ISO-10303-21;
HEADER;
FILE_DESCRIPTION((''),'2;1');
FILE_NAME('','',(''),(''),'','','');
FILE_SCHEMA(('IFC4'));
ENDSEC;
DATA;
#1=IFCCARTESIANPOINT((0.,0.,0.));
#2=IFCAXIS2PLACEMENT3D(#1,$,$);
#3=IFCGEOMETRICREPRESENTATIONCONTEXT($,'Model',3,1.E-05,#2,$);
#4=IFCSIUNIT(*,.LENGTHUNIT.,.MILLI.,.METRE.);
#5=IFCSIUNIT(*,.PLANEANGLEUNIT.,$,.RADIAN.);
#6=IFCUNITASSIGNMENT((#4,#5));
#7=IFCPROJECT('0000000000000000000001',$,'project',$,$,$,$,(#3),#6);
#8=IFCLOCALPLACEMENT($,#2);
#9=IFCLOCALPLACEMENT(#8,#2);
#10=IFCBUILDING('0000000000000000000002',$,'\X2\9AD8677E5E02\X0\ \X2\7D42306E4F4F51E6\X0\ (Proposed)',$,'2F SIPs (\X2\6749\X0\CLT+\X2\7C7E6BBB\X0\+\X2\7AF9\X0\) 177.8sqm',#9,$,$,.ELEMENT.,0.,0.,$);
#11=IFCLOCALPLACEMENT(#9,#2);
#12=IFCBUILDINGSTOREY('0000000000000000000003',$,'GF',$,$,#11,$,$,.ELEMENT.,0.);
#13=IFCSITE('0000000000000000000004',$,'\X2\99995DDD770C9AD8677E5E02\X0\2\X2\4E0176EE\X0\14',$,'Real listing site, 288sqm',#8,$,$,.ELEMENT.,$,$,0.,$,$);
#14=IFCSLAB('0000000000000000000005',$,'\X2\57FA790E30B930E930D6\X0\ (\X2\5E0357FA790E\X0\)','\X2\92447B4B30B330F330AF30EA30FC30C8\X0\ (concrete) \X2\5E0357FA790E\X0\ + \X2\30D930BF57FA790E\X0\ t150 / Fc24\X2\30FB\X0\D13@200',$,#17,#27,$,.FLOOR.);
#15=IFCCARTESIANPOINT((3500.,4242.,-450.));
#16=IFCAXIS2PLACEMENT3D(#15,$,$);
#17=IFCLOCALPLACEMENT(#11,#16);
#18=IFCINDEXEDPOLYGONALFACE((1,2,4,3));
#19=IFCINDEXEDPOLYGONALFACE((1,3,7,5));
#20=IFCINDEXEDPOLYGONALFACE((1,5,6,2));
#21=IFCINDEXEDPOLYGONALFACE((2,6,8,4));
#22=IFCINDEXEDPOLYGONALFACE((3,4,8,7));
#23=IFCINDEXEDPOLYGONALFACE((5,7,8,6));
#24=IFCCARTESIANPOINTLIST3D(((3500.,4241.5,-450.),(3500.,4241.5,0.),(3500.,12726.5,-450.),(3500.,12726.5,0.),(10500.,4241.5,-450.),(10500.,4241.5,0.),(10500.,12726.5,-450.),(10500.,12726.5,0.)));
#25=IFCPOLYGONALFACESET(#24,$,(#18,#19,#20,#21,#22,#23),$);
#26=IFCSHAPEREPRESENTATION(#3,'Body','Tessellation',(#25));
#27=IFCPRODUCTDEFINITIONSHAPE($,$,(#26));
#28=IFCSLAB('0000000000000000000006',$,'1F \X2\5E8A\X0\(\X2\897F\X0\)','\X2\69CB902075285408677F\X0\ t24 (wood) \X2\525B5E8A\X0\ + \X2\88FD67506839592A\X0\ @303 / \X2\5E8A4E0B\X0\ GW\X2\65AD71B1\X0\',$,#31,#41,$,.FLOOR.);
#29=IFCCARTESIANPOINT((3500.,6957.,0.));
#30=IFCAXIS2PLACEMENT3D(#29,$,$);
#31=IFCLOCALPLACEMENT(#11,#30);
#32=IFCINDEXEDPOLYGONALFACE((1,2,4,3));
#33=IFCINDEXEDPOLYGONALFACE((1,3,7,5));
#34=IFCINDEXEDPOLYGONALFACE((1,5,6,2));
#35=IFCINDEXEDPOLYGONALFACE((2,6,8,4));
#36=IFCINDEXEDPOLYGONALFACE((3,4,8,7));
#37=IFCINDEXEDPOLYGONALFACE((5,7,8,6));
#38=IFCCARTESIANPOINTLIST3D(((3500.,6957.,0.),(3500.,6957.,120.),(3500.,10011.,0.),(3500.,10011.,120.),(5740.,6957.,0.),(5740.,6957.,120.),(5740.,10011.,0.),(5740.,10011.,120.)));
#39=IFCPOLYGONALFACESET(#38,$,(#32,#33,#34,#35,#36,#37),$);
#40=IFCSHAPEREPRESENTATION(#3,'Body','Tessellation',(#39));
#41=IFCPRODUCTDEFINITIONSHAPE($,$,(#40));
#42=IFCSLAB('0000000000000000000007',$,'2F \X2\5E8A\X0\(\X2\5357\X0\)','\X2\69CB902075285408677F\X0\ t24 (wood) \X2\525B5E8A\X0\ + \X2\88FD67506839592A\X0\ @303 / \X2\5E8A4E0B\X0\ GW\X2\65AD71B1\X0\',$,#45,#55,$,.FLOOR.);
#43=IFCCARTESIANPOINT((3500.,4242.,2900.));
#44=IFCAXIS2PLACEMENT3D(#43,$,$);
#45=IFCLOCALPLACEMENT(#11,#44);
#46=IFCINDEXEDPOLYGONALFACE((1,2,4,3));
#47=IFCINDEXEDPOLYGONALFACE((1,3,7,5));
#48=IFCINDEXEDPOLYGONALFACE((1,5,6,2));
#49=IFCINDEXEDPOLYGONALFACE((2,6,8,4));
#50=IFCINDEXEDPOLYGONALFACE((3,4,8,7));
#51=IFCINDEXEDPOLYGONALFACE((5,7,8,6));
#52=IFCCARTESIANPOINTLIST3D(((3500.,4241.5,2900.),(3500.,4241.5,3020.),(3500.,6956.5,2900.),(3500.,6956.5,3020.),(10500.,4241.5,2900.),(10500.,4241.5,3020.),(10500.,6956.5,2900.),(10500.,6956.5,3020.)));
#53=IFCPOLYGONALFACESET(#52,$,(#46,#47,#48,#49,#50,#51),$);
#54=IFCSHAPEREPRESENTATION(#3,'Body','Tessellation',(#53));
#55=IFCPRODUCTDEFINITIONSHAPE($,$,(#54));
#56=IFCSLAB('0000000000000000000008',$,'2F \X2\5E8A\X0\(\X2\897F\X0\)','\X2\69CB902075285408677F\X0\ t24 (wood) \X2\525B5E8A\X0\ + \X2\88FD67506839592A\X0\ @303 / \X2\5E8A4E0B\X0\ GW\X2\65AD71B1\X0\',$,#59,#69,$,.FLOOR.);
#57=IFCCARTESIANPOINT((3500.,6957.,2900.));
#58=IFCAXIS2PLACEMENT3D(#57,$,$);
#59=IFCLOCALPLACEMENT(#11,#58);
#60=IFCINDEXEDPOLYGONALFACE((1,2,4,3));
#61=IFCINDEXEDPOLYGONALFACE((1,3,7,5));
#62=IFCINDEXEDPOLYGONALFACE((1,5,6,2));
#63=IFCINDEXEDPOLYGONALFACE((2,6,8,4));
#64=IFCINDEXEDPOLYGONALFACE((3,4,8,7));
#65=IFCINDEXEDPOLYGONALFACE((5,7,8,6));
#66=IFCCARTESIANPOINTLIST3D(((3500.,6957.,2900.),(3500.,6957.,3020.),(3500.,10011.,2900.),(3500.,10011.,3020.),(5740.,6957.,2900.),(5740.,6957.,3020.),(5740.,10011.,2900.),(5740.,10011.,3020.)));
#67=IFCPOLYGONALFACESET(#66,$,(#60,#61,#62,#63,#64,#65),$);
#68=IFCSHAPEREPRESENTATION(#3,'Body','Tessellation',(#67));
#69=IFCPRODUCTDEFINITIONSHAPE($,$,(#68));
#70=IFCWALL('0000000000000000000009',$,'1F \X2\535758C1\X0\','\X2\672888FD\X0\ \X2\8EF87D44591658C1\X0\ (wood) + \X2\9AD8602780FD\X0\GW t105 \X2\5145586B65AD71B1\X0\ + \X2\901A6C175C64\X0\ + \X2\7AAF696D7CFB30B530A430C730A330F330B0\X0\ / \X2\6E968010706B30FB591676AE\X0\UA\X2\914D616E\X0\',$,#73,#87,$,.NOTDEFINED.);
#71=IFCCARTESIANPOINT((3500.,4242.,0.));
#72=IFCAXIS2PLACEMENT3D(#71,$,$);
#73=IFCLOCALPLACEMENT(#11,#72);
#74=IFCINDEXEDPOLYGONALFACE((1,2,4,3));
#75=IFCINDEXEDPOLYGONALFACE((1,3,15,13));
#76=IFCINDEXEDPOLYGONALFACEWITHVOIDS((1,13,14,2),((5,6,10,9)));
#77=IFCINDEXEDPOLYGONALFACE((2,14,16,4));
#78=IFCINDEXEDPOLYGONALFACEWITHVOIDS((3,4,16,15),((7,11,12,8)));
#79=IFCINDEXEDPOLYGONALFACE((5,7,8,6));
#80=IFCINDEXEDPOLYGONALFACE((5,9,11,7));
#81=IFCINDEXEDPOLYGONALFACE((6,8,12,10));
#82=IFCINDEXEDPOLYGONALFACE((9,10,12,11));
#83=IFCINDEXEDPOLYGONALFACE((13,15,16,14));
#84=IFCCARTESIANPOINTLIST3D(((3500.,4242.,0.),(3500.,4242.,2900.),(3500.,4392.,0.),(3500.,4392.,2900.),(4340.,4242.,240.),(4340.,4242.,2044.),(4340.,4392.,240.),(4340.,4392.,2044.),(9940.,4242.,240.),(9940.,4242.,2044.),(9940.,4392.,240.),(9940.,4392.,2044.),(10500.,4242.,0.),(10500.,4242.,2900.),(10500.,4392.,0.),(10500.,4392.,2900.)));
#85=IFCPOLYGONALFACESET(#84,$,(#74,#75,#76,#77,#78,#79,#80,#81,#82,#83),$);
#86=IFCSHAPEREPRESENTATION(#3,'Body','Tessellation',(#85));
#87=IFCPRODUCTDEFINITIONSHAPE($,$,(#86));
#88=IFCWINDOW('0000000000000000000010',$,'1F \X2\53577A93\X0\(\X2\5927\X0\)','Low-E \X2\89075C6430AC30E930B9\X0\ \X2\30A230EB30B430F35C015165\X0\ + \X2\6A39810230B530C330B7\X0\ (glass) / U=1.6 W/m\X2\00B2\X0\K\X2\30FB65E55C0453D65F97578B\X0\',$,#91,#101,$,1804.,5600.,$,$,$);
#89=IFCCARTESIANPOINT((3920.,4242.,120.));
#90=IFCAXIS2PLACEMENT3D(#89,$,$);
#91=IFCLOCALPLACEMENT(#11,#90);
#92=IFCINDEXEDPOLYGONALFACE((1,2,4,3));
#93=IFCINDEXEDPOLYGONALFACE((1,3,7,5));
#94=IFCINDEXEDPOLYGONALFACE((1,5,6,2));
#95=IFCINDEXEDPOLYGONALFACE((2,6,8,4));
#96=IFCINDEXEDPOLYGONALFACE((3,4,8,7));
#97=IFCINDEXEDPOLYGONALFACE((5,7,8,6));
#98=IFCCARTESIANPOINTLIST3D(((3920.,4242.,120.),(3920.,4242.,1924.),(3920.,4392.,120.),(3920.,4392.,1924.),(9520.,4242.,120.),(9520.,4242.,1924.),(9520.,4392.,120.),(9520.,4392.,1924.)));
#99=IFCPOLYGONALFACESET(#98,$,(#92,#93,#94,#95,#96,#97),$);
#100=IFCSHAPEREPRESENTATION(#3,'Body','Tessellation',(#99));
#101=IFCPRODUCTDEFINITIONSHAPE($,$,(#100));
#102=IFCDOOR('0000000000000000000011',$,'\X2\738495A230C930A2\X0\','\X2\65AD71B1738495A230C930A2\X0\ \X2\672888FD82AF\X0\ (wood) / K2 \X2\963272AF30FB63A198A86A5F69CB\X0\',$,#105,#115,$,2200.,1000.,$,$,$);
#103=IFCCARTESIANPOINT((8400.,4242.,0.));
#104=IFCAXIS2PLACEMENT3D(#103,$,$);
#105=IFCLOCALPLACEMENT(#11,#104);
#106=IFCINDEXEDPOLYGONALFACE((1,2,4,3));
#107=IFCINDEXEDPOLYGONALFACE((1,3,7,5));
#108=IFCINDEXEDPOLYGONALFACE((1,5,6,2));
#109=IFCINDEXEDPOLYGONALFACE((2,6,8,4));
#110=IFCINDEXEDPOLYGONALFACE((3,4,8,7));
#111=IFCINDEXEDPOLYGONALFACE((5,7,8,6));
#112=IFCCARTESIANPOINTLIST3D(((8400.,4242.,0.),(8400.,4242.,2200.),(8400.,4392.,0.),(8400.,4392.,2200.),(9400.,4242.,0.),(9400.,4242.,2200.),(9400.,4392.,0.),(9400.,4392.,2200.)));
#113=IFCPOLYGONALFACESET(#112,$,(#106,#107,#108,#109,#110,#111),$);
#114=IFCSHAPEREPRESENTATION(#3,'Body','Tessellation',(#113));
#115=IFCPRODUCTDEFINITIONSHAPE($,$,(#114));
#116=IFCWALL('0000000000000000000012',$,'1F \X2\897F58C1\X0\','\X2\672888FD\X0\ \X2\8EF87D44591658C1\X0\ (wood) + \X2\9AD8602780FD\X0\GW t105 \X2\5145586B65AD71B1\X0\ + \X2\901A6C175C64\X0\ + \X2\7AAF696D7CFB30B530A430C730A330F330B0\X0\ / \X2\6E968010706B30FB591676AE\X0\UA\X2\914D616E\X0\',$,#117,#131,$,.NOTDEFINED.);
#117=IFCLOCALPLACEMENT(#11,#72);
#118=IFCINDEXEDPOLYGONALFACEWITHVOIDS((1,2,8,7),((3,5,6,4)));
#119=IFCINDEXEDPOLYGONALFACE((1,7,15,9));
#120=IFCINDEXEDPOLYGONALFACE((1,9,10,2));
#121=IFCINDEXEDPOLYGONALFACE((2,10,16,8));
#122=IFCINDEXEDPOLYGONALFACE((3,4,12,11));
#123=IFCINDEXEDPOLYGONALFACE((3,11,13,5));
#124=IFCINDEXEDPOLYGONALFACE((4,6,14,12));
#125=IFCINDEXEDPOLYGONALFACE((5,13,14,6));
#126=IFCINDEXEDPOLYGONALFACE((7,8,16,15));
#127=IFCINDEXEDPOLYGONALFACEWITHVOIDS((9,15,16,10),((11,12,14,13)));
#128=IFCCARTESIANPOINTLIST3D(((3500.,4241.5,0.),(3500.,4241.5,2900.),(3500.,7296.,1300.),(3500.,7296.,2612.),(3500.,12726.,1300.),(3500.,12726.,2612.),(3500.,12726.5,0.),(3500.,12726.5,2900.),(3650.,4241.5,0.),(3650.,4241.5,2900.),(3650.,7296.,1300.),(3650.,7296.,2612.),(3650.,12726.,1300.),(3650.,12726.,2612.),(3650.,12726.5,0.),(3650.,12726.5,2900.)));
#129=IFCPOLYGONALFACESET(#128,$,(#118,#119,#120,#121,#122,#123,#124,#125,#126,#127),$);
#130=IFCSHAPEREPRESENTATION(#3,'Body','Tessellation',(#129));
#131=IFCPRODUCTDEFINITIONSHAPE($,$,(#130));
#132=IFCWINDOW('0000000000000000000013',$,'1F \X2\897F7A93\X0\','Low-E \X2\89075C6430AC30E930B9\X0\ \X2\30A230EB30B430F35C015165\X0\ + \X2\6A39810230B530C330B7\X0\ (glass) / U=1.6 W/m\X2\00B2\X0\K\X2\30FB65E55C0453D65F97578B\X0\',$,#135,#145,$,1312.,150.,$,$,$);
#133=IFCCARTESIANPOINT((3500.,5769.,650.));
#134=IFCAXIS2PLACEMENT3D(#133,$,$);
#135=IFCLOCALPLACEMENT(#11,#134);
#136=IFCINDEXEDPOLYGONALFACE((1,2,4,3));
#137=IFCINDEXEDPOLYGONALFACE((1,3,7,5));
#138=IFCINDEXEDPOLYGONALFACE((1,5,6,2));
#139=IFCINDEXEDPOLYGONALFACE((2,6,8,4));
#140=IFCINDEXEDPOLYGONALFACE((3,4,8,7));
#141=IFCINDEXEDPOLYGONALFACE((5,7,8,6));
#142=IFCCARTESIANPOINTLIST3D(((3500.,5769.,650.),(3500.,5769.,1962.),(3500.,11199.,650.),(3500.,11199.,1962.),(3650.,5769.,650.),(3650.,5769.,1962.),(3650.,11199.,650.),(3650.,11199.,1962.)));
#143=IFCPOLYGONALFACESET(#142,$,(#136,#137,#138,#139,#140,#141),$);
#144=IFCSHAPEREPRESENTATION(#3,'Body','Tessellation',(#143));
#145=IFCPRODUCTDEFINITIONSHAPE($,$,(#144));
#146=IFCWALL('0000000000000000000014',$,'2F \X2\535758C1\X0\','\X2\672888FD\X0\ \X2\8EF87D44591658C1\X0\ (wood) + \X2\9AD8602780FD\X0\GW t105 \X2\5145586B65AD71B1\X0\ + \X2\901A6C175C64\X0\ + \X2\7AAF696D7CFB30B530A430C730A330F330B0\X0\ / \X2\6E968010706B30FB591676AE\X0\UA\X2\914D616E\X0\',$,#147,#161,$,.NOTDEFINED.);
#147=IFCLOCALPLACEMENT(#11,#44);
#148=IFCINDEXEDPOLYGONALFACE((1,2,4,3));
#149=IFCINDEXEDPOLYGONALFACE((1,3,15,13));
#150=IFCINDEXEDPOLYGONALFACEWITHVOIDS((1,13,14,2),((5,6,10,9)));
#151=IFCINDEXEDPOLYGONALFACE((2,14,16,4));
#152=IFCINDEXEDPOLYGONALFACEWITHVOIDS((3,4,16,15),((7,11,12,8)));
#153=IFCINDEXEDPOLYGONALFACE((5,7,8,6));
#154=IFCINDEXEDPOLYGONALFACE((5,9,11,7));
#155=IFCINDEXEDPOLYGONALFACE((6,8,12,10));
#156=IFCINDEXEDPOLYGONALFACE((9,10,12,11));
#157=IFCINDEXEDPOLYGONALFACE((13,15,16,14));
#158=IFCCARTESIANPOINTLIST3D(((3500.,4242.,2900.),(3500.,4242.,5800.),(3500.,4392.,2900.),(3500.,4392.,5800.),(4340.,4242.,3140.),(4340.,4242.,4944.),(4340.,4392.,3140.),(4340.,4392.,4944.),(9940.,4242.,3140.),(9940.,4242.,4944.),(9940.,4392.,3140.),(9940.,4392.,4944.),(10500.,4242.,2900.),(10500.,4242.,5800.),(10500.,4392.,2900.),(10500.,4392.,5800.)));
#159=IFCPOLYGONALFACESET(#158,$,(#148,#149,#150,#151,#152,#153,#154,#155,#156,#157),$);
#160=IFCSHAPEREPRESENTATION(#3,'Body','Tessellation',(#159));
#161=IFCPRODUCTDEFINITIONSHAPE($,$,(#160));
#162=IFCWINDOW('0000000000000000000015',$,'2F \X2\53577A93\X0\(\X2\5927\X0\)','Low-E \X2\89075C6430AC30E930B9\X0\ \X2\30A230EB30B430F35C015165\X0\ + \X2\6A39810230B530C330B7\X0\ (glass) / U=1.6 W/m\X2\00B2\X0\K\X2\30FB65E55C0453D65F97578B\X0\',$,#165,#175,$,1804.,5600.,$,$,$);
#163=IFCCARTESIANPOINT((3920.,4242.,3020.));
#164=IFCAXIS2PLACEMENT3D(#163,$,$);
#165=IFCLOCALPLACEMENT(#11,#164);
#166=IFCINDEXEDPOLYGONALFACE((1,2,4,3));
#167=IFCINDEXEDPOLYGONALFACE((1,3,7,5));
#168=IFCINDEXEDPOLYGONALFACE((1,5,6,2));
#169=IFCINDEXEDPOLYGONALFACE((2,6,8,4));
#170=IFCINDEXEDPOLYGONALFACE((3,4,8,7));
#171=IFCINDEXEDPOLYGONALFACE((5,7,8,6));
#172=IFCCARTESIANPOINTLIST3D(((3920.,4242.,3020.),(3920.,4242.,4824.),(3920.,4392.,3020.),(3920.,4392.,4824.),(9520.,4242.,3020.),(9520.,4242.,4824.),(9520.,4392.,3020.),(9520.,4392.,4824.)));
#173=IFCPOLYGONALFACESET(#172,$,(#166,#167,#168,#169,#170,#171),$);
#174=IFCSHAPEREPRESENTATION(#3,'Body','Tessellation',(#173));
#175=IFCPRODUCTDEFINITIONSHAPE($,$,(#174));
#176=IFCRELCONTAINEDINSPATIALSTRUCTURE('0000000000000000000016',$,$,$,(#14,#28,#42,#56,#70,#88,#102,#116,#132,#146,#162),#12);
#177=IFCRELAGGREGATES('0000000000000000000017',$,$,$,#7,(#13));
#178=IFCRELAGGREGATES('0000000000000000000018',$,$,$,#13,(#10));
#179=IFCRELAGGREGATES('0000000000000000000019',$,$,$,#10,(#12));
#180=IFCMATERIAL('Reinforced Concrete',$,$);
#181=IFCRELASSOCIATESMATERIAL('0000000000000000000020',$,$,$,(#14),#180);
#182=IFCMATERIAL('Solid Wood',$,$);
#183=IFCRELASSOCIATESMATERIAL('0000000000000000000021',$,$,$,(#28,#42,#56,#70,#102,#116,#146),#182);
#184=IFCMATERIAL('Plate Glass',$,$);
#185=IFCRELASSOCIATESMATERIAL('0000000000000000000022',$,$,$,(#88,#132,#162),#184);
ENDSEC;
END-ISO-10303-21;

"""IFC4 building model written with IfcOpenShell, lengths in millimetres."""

from ifc_helpers import new_model, si_unit, frame, frame_2d, origin, place, context, project, spatial, rectangle, extrude, material, element, fill, save


model = new_model("IFC4")

# Units and contexts
model_context = context("Model", 3, precision=1e-05, world=origin())
ifc_project = project(units=[si_unit("LENGTHUNIT", "METRE", prefix="MILLI"), si_unit("PLANEANGLEUNIT", "RADIAN")], contexts=[model_context])

# Site, building, storey
site_placement = place(None, origin())
site = spatial("IfcSite", under=ifc_project, at=site_placement, Name="香川県高松市2丁目14", ObjectType="Real listing site, 288sqm", CompositionType="ELEMENT", RefElevation=0.0)
building_placement = place(site_placement, origin())
building = spatial("IfcBuilding", under=site, at=building_placement, Name="高松市 終の住処 (Proposed)", ObjectType="2F SIPs (杉CLT+籾殻+竹) 177.8sqm", CompositionType="ELEMENT", ElevationOfRefHeight=0.0, ElevationOfTerrain=0.0)
storey_placement = place(building_placement, origin())
storey = spatial("IfcBuildingStorey", under=building, at=storey_placement, Name="GF", CompositionType="ELEMENT", Elevation=0.0)

# Slabs
ifc_material_1 = material(Name="Reinforced Concrete")
slab_1_placement = place(storey_placement, frame((3500.0, 4242.0, -450.0)))
element("IfcSlab", 1, at=slab_1_placement, inside=storey, material=ifc_material_1, Name="基礎スラブ (布基礎)", Description="鉄筋コンクリート (concrete) 布基礎 + ベタ基礎 t150 / Fc24・D13@200", PredefinedType="FLOOR", context=model_context, shape_type="SweptSolid", body=[
    extrude(rectangle(XDim=7000.0, YDim=8485.0, at=frame_2d((3500.0, 4242.0))), frame((3500.0, 4242.0, -450.0)), (0.0, 0.0, 1.0), 450.0),
])
ifc_material_2 = material(Name="Solid Wood")
slab_2_placement = place(storey_placement, frame((3500.0, 6957.0, 0.0)))
element("IfcSlab", 2, at=slab_2_placement, inside=storey, material=ifc_material_2, Name="1F 床(西)", Description="構造用合板 t24 (wood) 剛床 + 製材根太 @303 / 床下 GW断熱", PredefinedType="FLOOR", context=model_context, shape_type="SweptSolid", body=[
    extrude(rectangle(XDim=2240.0, YDim=3054.0, at=frame_2d((1120.0, 1527.0))), frame((3500.0, 6957.0, 0.0)), (0.0, 0.0, 1.0), 120.0),
])
slab_3_placement = place(storey_placement, frame((3500.0, 4242.0, 2900.0)))
element("IfcSlab", 3, at=slab_3_placement, inside=storey, material=ifc_material_2, Name="2F 床(南)", Description="構造用合板 t24 (wood) 剛床 + 製材根太 @303 / 床下 GW断熱", PredefinedType="FLOOR", context=model_context, shape_type="SweptSolid", body=[
    extrude(rectangle(XDim=7000.0, YDim=2715.0, at=frame_2d((3500.0, 1357.0))), frame((3500.0, 4242.0, 2900.0)), (0.0, 0.0, 1.0), 120.0),
])
slab_4_placement = place(storey_placement, frame((3500.0, 6957.0, 2900.0)))
element("IfcSlab", 4, at=slab_4_placement, inside=storey, material=ifc_material_2, Name="2F 床(西)", Description="構造用合板 t24 (wood) 剛床 + 製材根太 @303 / 床下 GW断熱", PredefinedType="FLOOR", context=model_context, shape_type="SweptSolid", body=[
    extrude(rectangle(XDim=2240.0, YDim=3054.0, at=frame_2d((1120.0, 1527.0))), frame((3500.0, 6957.0, 2900.0)), (0.0, 0.0, 1.0), 120.0),
])

# Wall, openings, window, door
wall_1_placement = place(storey_placement, frame((3500.0, 4242.0, 0.0)))
wall_1 = element("IfcWall", 5, at=wall_1_placement, inside=storey, material=ifc_material_2, Name="1F 南壁", Description="木製 軸組外壁 (wood) + 高性能GW t105 充填断熱 + 通気層 + 窯業系サイディング / 準耐火・外皮UA配慮", PredefinedType="NOTDEFINED", context=model_context, shape_type="SweptSolid", body=[
    extrude(rectangle(XDim=7000.0, YDim=150.0, at=frame_2d((3500.0, 75.0))), frame((3500.0, 4242.0, 0.0)), (0.0, 0.0, 1.0), 2900.0),
])
opening_1_placement = place(storey_placement, frame((3920.0, 4242.0, 120.0)))
opening_1 = element("IfcOpeningElement", 6, at=opening_1_placement, cuts=wall_1, PredefinedType="NOTDEFINED", context=model_context, shape_type="SweptSolid", body=[
    extrude(rectangle(XDim=5600.0, YDim=150.0, at=frame_2d((2800.0, 75.0))), frame((3920.0, 4242.0, 120.0)), (0.0, 0.0, 1.0), 1804.0),
])
opening_2_placement = place(storey_placement, frame((8400.0, 4242.0, 0.0)))
opening_2 = element("IfcOpeningElement", 7, at=opening_2_placement, cuts=wall_1, PredefinedType="NOTDEFINED", context=model_context, shape_type="SweptSolid", body=[
    extrude(rectangle(XDim=1000.0, YDim=150.0, at=frame_2d((500.0, 75.0))), frame((8400.0, 4242.0, 0.0)), (0.0, 0.0, 1.0), 2200.0),
])
ifc_material_3 = material(Name="Plate Glass")
window_1_placement = place(storey_placement, frame((3920.0, 4242.0, 120.0)))
window_1 = element("IfcWindow", 8, at=window_1_placement, inside=storey, material=ifc_material_3, Name="1F 南窓(大)", Description="Low-E 複層ガラス アルゴン封入 + 樹脂サッシ (glass) / U=1.6 W/m²K・日射取得型", OverallHeight=1804.0, OverallWidth=5600.0, context=model_context, shape_type="SweptSolid", body=[
    extrude(rectangle(XDim=5600.0, YDim=150.0, at=frame_2d((2800.0, 75.0))), frame((3920.0, 4242.0, 120.0)), (0.0, 0.0, 1.0), 1804.0),
])
fill(opening_1, window_1)
door_placement = place(storey_placement, frame((8400.0, 4242.0, 0.0)))
door = element("IfcDoor", 9, at=door_placement, inside=storey, material=ifc_material_2, Name="玄関ドア", Description="断熱玄関ドア 木製芯 (wood) / K2 防犯・採風機構", OverallHeight=2200.0, OverallWidth=1000.0, context=model_context, shape_type="SweptSolid", body=[
    extrude(rectangle(XDim=1000.0, YDim=150.0, at=frame_2d((500.0, 75.0))), frame((8400.0, 4242.0, 0.0)), (0.0, 0.0, 1.0), 2200.0),
])
fill(opening_2, door)

# Walls, openings, windows
wall_2_placement = place(storey_placement, frame((3500.0, 4242.0, 0.0)))
wall_2 = element("IfcWall", 10, at=wall_2_placement, inside=storey, material=ifc_material_2, Name="1F 西壁", Description="木製 軸組外壁 (wood) + 高性能GW t105 充填断熱 + 通気層 + 窯業系サイディング / 準耐火・外皮UA配慮", PredefinedType="NOTDEFINED", context=model_context, shape_type="SweptSolid", body=[
    extrude(rectangle(XDim=150.0, YDim=8485.0, at=frame_2d((75.0, 4242.0))), frame((3500.0, 4242.0, 0.0)), (0.0, 0.0, 1.0), 2900.0),
])
opening_3_placement = place(storey_placement, frame((3500.0, 5769.0, 650.0)))
opening_3 = element("IfcOpeningElement", 11, at=opening_3_placement, cuts=wall_2, PredefinedType="NOTDEFINED", context=model_context, shape_type="SweptSolid", body=[
    extrude(rectangle(XDim=150.0, YDim=5430.0, at=frame_2d((75.0, 2715.0))), frame((3500.0, 5769.0, 650.0)), (0.0, 0.0, 1.0), 1312.0),
])
window_2_placement = place(storey_placement, frame((3500.0, 5769.0, 650.0)))
window_2 = element("IfcWindow", 12, at=window_2_placement, inside=storey, material=ifc_material_3, Name="1F 西窓", Description="Low-E 複層ガラス アルゴン封入 + 樹脂サッシ (glass) / U=1.6 W/m²K・日射取得型", OverallHeight=1312.0, OverallWidth=150.0, context=model_context, shape_type="SweptSolid", body=[
    extrude(rectangle(XDim=150.0, YDim=5430.0, at=frame_2d((75.0, 2715.0))), frame((3500.0, 5769.0, 650.0)), (0.0, 0.0, 1.0), 1312.0),
])
fill(opening_3, window_2)
wall_3_placement = place(storey_placement, frame((3500.0, 4242.0, 2900.0)))
wall_3 = element("IfcWall", 13, at=wall_3_placement, inside=storey, material=ifc_material_2, Name="2F 南壁", Description="木製 軸組外壁 (wood) + 高性能GW t105 充填断熱 + 通気層 + 窯業系サイディング / 準耐火・外皮UA配慮", PredefinedType="NOTDEFINED", context=model_context, shape_type="SweptSolid", body=[
    extrude(rectangle(XDim=7000.0, YDim=150.0, at=frame_2d((3500.0, 75.0))), frame((3500.0, 4242.0, 2900.0)), (0.0, 0.0, 1.0), 2900.0),
])
opening_4_placement = place(storey_placement, frame((3920.0, 4242.0, 3020.0)))
opening_4 = element("IfcOpeningElement", 14, at=opening_4_placement, cuts=wall_3, PredefinedType="NOTDEFINED", context=model_context, shape_type="SweptSolid", body=[
    extrude(rectangle(XDim=5600.0, YDim=150.0, at=frame_2d((2800.0, 75.0))), frame((3920.0, 4242.0, 3020.0)), (0.0, 0.0, 1.0), 1804.0),
])
window_3_placement = place(storey_placement, frame((3920.0, 4242.0, 3020.0)))
window_3 = element("IfcWindow", 15, at=window_3_placement, inside=storey, material=ifc_material_3, Name="2F 南窓(大)", Description="Low-E 複層ガラス アルゴン封入 + 樹脂サッシ (glass) / U=1.6 W/m²K・日射取得型", OverallHeight=1804.0, OverallWidth=5600.0, context=model_context, shape_type="SweptSolid", body=[
    extrude(rectangle(XDim=5600.0, YDim=150.0, at=frame_2d((2800.0, 75.0))), frame((3920.0, 4242.0, 3020.0)), (0.0, 0.0, 1.0), 1804.0),
])
fill(opening_4, window_3)

save(model, "model.ifc")
